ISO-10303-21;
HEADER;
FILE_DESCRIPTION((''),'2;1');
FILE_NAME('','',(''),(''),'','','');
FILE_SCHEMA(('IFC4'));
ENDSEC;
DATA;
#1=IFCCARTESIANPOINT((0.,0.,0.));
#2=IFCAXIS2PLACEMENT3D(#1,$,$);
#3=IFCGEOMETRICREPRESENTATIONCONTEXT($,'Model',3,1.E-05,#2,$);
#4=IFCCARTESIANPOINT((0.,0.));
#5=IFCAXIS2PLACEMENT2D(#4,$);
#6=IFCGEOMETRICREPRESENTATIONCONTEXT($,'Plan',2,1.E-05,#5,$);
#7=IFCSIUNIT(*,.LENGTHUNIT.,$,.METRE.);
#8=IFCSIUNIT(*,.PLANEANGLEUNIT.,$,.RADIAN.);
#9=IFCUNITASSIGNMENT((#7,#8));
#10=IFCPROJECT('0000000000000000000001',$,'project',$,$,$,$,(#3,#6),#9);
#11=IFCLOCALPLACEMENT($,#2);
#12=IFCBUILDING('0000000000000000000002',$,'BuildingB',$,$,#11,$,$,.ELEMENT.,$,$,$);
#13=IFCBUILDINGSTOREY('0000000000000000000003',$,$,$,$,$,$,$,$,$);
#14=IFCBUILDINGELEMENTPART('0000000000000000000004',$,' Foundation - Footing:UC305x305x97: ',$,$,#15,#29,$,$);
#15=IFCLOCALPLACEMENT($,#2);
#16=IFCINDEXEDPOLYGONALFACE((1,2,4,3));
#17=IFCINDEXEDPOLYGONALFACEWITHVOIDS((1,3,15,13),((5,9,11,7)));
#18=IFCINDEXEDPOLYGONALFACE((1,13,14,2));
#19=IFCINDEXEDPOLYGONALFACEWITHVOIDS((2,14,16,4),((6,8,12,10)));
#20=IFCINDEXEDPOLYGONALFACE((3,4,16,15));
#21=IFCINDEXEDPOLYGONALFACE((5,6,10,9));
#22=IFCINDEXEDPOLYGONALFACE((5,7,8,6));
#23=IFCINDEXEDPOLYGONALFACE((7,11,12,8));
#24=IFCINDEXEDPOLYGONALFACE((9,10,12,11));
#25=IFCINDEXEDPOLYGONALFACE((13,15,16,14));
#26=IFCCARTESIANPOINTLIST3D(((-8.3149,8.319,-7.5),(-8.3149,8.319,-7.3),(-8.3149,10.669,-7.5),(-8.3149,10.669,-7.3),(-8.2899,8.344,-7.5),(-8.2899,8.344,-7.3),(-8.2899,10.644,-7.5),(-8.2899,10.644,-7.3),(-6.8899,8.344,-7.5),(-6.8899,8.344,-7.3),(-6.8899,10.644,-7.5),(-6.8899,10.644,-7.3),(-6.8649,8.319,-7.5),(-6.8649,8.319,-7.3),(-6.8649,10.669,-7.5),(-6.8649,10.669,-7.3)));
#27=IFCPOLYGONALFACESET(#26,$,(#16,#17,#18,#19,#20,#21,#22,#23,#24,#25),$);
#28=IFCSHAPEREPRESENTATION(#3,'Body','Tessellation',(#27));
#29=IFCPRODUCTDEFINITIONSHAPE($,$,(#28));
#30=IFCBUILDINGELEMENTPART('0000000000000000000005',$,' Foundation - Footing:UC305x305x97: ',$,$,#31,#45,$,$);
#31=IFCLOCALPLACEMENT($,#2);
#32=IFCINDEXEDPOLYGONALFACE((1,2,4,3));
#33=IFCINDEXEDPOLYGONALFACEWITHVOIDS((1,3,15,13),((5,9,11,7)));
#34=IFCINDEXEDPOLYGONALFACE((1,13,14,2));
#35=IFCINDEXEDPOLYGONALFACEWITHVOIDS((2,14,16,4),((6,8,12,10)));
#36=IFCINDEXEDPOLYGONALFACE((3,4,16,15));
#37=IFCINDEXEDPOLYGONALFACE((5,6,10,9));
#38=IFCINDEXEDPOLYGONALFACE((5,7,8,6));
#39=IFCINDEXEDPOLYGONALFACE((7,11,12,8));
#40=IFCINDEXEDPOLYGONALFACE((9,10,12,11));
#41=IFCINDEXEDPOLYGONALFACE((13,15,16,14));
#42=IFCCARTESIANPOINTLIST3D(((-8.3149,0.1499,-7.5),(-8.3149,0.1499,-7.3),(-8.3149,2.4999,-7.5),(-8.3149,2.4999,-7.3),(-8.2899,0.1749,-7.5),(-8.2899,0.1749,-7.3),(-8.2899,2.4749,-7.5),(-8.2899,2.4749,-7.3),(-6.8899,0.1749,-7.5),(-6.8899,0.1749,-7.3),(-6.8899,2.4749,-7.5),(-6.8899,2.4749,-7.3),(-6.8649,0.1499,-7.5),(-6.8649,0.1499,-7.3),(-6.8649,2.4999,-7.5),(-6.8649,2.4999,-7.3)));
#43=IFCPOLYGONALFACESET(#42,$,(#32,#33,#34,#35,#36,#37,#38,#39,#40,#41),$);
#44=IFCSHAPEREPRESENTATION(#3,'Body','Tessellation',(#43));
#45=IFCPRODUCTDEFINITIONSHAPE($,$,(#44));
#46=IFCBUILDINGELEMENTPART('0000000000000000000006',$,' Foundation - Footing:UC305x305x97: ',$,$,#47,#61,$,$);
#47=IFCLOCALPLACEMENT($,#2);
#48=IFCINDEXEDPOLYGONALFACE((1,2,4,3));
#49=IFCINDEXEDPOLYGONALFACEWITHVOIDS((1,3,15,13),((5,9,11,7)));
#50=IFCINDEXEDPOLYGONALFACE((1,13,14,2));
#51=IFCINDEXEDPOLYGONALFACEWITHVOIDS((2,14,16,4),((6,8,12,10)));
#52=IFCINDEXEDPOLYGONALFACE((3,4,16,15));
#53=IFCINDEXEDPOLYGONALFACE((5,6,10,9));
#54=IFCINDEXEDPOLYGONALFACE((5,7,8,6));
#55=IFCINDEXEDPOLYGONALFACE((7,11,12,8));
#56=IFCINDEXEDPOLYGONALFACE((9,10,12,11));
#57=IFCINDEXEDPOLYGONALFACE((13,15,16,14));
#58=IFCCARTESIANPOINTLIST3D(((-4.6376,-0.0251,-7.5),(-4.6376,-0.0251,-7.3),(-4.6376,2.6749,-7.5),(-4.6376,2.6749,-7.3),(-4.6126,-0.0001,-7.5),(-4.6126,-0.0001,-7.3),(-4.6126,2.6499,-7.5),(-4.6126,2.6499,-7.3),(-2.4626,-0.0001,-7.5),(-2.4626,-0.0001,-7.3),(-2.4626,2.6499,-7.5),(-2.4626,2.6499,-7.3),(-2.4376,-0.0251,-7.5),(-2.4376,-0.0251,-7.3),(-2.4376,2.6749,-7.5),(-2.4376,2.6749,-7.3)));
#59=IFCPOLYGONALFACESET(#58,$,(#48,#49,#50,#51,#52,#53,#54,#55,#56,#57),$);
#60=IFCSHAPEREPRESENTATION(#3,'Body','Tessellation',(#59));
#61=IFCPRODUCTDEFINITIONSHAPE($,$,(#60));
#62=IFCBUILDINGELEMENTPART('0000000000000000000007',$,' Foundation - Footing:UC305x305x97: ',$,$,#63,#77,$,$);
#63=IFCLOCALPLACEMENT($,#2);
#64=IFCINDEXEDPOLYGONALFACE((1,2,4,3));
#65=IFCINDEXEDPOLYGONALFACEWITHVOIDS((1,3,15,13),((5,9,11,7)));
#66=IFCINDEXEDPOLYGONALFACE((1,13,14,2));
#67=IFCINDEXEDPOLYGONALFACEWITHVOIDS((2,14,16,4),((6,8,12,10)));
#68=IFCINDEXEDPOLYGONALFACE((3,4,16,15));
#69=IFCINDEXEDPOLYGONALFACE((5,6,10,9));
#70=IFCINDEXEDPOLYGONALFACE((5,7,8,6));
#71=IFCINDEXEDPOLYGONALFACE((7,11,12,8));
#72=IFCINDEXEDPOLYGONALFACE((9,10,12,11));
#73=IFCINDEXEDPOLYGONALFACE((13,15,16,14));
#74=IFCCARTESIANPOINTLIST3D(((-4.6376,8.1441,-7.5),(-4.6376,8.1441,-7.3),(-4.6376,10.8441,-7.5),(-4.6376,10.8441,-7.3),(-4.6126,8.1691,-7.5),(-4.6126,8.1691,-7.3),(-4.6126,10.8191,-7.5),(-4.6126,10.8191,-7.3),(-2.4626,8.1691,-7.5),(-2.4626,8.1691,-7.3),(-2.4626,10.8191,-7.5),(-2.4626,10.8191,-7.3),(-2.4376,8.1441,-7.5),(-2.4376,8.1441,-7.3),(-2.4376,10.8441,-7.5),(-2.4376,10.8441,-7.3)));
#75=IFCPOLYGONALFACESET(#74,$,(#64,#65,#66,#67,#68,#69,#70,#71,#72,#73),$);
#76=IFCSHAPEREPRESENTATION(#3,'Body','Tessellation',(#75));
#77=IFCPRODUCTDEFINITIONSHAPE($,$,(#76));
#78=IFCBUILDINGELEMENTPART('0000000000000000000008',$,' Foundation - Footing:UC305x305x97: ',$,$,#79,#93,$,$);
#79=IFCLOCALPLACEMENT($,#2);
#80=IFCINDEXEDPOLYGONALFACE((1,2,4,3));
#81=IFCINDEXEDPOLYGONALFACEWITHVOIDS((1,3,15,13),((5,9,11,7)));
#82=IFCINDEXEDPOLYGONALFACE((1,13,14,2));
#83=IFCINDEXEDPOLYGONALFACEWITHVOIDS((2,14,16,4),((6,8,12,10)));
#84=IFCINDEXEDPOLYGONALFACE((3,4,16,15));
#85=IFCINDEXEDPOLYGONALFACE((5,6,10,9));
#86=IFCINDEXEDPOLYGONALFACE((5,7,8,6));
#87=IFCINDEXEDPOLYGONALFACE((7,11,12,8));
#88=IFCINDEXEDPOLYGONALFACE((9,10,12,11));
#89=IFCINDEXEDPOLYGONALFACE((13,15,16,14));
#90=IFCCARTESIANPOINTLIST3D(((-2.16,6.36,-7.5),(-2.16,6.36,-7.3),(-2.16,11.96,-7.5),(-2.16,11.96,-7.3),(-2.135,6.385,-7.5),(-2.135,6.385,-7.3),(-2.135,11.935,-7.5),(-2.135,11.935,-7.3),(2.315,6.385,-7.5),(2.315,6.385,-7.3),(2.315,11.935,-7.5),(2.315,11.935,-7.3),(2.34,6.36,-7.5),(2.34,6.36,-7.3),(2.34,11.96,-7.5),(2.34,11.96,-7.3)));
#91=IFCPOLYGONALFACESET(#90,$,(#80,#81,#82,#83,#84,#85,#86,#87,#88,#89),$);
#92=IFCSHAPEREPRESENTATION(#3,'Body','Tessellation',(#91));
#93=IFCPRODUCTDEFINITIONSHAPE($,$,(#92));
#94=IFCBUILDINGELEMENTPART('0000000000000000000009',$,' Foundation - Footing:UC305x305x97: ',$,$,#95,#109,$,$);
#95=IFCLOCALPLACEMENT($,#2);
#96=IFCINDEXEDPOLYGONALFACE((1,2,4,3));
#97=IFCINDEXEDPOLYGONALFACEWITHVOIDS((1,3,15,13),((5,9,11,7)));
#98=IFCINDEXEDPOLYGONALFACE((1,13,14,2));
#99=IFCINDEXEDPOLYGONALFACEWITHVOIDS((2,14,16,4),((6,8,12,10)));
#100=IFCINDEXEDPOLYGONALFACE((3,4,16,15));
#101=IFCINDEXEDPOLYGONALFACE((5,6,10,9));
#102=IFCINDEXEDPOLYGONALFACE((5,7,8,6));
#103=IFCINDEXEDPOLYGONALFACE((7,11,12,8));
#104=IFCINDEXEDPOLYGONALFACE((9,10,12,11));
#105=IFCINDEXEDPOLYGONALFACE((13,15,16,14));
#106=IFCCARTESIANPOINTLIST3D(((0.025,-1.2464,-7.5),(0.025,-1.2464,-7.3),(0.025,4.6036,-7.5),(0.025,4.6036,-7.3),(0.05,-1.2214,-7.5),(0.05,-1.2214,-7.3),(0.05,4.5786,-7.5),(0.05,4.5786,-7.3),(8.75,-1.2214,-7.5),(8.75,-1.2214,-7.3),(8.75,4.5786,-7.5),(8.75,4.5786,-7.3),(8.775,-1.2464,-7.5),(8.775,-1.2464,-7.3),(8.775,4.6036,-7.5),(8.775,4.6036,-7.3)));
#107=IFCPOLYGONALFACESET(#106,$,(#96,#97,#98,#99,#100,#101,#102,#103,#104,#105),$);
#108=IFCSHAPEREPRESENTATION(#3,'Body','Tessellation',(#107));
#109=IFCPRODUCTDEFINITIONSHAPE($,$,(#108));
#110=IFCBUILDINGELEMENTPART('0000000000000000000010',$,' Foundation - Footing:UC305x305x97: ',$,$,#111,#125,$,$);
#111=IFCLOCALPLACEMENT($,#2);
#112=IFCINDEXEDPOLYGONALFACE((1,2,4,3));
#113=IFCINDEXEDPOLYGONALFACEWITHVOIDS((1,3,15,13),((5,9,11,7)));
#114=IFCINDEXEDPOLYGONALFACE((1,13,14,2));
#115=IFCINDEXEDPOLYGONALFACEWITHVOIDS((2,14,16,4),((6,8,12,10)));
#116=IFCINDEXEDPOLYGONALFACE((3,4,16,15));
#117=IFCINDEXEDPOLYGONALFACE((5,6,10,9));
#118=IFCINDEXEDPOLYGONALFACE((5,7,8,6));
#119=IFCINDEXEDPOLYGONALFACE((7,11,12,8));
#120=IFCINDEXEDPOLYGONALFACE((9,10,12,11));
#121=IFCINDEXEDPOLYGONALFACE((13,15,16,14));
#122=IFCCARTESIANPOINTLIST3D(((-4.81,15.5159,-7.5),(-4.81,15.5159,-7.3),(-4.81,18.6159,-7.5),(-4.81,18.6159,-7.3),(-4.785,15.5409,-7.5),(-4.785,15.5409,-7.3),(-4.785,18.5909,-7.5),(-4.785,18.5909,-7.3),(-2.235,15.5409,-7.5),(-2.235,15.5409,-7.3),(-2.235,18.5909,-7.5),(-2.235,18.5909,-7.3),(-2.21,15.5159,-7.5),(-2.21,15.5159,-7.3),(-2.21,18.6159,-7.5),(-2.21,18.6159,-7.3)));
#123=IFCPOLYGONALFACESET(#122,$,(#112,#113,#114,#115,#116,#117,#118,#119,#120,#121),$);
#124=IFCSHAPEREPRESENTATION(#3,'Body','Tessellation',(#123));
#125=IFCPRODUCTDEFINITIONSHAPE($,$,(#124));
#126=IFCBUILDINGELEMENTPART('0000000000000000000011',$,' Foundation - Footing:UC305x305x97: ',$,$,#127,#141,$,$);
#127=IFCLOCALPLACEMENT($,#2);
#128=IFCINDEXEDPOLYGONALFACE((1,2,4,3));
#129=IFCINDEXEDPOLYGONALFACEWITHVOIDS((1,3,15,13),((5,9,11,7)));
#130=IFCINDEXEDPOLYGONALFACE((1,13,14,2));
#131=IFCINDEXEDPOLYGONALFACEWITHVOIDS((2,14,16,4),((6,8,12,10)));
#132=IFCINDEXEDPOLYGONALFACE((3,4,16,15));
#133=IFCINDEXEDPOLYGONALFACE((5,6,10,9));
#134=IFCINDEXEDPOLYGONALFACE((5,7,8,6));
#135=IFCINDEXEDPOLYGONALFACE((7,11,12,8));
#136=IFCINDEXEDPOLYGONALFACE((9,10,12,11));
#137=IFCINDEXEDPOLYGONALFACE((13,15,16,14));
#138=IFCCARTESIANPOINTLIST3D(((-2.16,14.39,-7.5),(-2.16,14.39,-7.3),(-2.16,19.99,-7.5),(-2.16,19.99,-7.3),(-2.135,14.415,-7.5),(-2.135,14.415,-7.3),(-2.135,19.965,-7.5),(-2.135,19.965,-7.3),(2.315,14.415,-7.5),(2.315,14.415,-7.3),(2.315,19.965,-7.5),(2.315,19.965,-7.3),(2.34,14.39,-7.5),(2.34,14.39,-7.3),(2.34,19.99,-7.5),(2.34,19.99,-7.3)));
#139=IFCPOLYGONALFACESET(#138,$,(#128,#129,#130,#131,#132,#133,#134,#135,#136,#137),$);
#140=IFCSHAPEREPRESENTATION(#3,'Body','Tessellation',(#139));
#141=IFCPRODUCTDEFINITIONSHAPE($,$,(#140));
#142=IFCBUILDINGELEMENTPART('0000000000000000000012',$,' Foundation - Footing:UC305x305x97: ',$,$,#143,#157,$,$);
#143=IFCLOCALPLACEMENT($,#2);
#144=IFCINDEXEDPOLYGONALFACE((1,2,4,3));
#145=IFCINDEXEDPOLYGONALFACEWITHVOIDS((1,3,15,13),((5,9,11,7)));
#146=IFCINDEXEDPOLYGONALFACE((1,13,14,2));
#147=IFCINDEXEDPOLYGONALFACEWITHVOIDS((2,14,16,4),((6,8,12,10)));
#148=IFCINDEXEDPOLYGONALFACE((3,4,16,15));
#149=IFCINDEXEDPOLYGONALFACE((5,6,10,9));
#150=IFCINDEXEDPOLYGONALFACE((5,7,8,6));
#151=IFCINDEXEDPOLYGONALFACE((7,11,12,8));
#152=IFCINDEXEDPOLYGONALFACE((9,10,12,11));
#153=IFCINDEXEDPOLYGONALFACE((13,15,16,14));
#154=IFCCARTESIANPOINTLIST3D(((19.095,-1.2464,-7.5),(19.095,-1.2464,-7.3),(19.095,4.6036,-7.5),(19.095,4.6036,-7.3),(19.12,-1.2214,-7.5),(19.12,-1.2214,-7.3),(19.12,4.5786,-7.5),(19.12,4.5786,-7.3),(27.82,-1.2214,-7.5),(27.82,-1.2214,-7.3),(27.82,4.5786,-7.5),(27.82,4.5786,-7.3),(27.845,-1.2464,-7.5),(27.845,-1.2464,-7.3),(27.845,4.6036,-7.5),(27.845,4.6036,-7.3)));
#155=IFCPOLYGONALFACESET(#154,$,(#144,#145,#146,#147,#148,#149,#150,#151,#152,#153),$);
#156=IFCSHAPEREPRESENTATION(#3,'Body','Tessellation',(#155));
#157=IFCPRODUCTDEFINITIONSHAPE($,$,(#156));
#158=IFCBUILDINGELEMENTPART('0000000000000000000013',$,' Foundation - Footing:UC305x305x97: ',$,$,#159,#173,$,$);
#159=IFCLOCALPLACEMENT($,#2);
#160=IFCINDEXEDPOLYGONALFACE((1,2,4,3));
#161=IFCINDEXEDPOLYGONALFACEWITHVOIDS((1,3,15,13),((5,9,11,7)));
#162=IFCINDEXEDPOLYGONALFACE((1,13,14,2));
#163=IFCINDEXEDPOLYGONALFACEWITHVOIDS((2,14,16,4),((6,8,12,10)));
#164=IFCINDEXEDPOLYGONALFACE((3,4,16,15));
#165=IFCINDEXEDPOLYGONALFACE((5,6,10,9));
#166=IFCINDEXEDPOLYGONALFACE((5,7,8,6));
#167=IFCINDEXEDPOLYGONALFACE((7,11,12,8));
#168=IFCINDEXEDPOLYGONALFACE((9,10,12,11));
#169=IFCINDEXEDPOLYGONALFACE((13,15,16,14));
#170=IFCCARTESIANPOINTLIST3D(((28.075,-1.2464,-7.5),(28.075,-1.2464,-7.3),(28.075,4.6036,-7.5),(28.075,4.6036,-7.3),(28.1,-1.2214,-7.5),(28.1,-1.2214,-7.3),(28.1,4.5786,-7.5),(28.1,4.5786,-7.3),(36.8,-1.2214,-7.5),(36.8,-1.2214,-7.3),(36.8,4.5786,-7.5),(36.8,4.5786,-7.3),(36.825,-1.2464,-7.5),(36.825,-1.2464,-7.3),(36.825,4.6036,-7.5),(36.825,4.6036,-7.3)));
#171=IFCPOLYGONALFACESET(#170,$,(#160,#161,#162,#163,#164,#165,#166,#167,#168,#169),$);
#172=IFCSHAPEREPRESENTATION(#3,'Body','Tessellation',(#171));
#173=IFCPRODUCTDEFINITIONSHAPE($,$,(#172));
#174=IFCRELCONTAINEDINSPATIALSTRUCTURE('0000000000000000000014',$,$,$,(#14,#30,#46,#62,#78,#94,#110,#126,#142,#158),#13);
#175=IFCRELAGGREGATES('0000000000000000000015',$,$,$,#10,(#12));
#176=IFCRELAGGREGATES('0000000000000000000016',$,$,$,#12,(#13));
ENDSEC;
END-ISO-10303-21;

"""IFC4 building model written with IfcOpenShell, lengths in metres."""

from ifc_helpers import new_model, si_unit, origin, origin_2d, place, context, project, spatial, polyline, outline, extrude, element, save


model = new_model("IFC4")

# Units and contexts
model_context = context("Model", 3, precision=1e-05, world=origin())
plan_context = context("Plan", 2, precision=1e-05, world=origin_2d())
ifc_project = project(units=[si_unit("LENGTHUNIT", "METRE"), si_unit("PLANEANGLEUNIT", "RADIAN")], contexts=[model_context, plan_context])

# Building, storey
building_placement = place(None, origin())
building = spatial("IfcBuilding", under=ifc_project, at=building_placement, Name="BuildingB", CompositionType="ELEMENT")
storey = spatial("IfcBuildingStorey", under=building)

# Building element parts, openings
building_element_part_1 = element("IfcBuildingElementPart", 1, inside=storey, Name=" Foundation - Footing:UC305x305x97: ", context=model_context, shape_type="SweptSolid", body=[
    extrude(outline(polyline([(-8.3149, 8.319, -7.5), (-6.8649, 8.319, -7.5), (-6.8649, 10.669, -7.5), (-8.3149, 10.669, -7.5), (-8.3149, 8.319, -7.5)])), None, (0.0, 0.0, 1.0), 0.2),
])
element("IfcOpeningElement", 2, inside=storey, cuts=building_element_part_1, context=model_context, shape_type="SweptSolid", body=[
    extrude(outline(polyline([(-8.2899, 8.344, -7.5), (-6.8899, 8.344, -7.5), (-6.8899, 10.644, -7.5), (-8.2899, 10.644, -7.5), (-8.2899, 8.344, -7.5)])), None, (0.0, 0.0, 1.0), 0.2),
])
building_element_part_2 = element("IfcBuildingElementPart", 3, inside=storey, Name=" Foundation - Footing:UC305x305x97: ", context=model_context, shape_type="SweptSolid", body=[
    extrude(outline(polyline([(-8.3149, 0.1499, -7.5), (-6.8649, 0.1499, -7.5), (-6.8649, 2.4999, -7.5), (-8.3149, 2.4999, -7.5), (-8.3149, 0.1499, -7.5)])), None, (0.0, 0.0, 1.0), 0.2),
])
element("IfcOpeningElement", 4, inside=storey, cuts=building_element_part_2, context=model_context, shape_type="SweptSolid", body=[
    extrude(outline(polyline([(-8.2899, 0.1749, -7.5), (-6.8899, 0.1749, -7.5), (-6.8899, 2.4749, -7.5), (-8.2899, 2.4749, -7.5), (-8.2899, 0.1749, -7.5)])), None, (0.0, 0.0, 1.0), 0.2),
])
building_element_part_3 = element("IfcBuildingElementPart", 5, inside=storey, Name=" Foundation - Footing:UC305x305x97: ", context=model_context, shape_type="SweptSolid", body=[
    extrude(outline(polyline([(-4.6376, -0.0251, -7.5), (-2.4376, -0.0251, -7.5), (-2.4376, 2.6749, -7.5), (-4.6376, 2.6749, -7.5), (-4.6376, -0.0251, -7.5)])), None, (0.0, 0.0, 1.0), 0.2),
])
element("IfcOpeningElement", 6, inside=storey, cuts=building_element_part_3, context=model_context, shape_type="SweptSolid", body=[
    extrude(outline(polyline([(-4.6126, -0.0001, -7.5), (-2.4626, -0.0001, -7.5), (-2.4626, 2.6499, -7.5), (-4.6126, 2.6499, -7.5), (-4.6126, -0.0001, -7.5)])), None, (0.0, 0.0, 1.0), 0.2),
])
building_element_part_4 = element("IfcBuildingElementPart", 7, inside=storey, Name=" Foundation - Footing:UC305x305x97: ", context=model_context, shape_type="SweptSolid", body=[
    extrude(outline(polyline([(-4.6376, 8.1441, -7.5), (-2.4376, 8.1441, -7.5), (-2.4376, 10.8441, -7.5), (-4.6376, 10.8441, -7.5), (-4.6376, 8.1441, -7.5)])), None, (0.0, 0.0, 1.0), 0.2),
])
element("IfcOpeningElement", 8, inside=storey, cuts=building_element_part_4, context=model_context, shape_type="SweptSolid", body=[
    extrude(outline(polyline([(-4.6126, 8.1691, -7.5), (-2.4626, 8.1691, -7.5), (-2.4626, 10.8191, -7.5), (-4.6126, 10.8191, -7.5), (-4.6126, 8.1691, -7.5)])), None, (0.0, 0.0, 1.0), 0.2),
])
building_element_part_5 = element("IfcBuildingElementPart", 9, inside=storey, Name=" Foundation - Footing:UC305x305x97: ", context=model_context, shape_type="SweptSolid", body=[
    extrude(outline(polyline([(-2.16, 6.36, -7.5), (2.34, 6.36, -7.5), (2.34, 11.96, -7.5), (-2.16, 11.96, -7.5), (-2.16, 6.36, -7.5)])), None, (0.0, 0.0, 1.0), 0.2),
])
element("IfcOpeningElement", 10, inside=storey, cuts=building_element_part_5, context=model_context, shape_type="SweptSolid", body=[
    extrude(outline(polyline([(-2.135, 6.385, -7.5), (2.315, 6.385, -7.5), (2.315, 11.935, -7.5), (-2.135, 11.935, -7.5), (-2.135, 6.385, -7.5)])), None, (0.0, 0.0, 1.0), 0.2),
])
building_element_part_6 = element("IfcBuildingElementPart", 11, inside=storey, Name=" Foundation - Footing:UC305x305x97: ", context=model_context, shape_type="SweptSolid", body=[
    extrude(outline(polyline([(0.025, -1.2464, -7.5), (8.775, -1.2464, -7.5), (8.775, 4.6036, -7.5), (0.025, 4.6036, -7.5), (0.025, -1.2464, -7.5)])), None, (0.0, 0.0, 1.0), 0.2),
])
element("IfcOpeningElement", 12, inside=storey, cuts=building_element_part_6, context=model_context, shape_type="SweptSolid", body=[
    extrude(outline(polyline([(0.05, -1.2214, -7.5), (8.75, -1.2214, -7.5), (8.75, 4.5786, -7.5), (0.05, 4.5786, -7.5), (0.05, -1.2214, -7.5)])), None, (0.0, 0.0, 1.0), 0.2),
])
building_element_part_7 = element("IfcBuildingElementPart", 13, inside=storey, Name=" Foundation - Footing:UC305x305x97: ", context=model_context, shape_type="SweptSolid", body=[
    extrude(outline(polyline([(-4.81, 15.5159, -7.5), (-2.21, 15.5159, -7.5), (-2.21, 18.6159, -7.5), (-4.81, 18.6159, -7.5), (-4.81, 15.5159, -7.5)])), None, (0.0, 0.0, 1.0), 0.2),
])
element("IfcOpeningElement", 14, inside=storey, cuts=building_element_part_7, context=model_context, shape_type="SweptSolid", body=[
    extrude(outline(polyline([(-4.785, 15.5409, -7.5), (-2.235, 15.5409, -7.5), (-2.235, 18.5909, -7.5), (-4.785, 18.5909, -7.5), (-4.785, 15.5409, -7.5)])), None, (0.0, 0.0, 1.0), 0.2),
])
building_element_part_8 = element("IfcBuildingElementPart", 15, inside=storey, Name=" Foundation - Footing:UC305x305x97: ", context=model_context, shape_type="SweptSolid", body=[
    extrude(outline(polyline([(-2.16, 14.39, -7.5), (2.34, 14.39, -7.5), (2.34, 19.99, -7.5), (-2.16, 19.99, -7.5), (-2.16, 14.39, -7.5)])), None, (0.0, 0.0, 1.0), 0.2),
])
element("IfcOpeningElement", 16, inside=storey, cuts=building_element_part_8, context=model_context, shape_type="SweptSolid", body=[
    extrude(outline(polyline([(-2.135, 14.415, -7.5), (2.315, 14.415, -7.5), (2.315, 19.965, -7.5), (-2.135, 19.965, -7.5), (-2.135, 14.415, -7.5)])), None, (0.0, 0.0, 1.0), 0.2),
])
building_element_part_9 = element("IfcBuildingElementPart", 17, inside=storey, Name=" Foundation - Footing:UC305x305x97: ", context=model_context, shape_type="SweptSolid", body=[
    extrude(outline(polyline([(19.095, -1.2464, -7.5), (27.845, -1.2464, -7.5), (27.845, 4.6036, -7.5), (19.095, 4.6036, -7.5), (19.095, -1.2464, -7.5)])), None, (0.0, 0.0, 1.0), 0.2),
])
element("IfcOpeningElement", 18, inside=storey, cuts=building_element_part_9, context=model_context, shape_type="SweptSolid", body=[
    extrude(outline(polyline([(19.12, -1.2214, -7.5), (27.82, -1.2214, -7.5), (27.82, 4.5786, -7.5), (19.12, 4.5786, -7.5), (19.12, -1.2214, -7.5)])), None, (0.0, 0.0, 1.0), 0.2),
])
building_element_part_10 = element("IfcBuildingElementPart", 19, inside=storey, Name=" Foundation - Footing:UC305x305x97: ", context=model_context, shape_type="SweptSolid", body=[
    extrude(outline(polyline([(28.075, -1.2464, -7.5), (36.825, -1.2464, -7.5), (36.825, 4.6036, -7.5), (28.075, 4.6036, -7.5), (28.075, -1.2464, -7.5)])), None, (0.0, 0.0, 1.0), 0.2),
])
element("IfcOpeningElement", 20, inside=storey, cuts=building_element_part_10, context=model_context, shape_type="SweptSolid", body=[
    extrude(outline(polyline([(28.1, -1.2214, -7.5), (36.8, -1.2214, -7.5), (36.8, 4.5786, -7.5), (28.1, 4.5786, -7.5), (28.1, -1.2214, -7.5)])), None, (0.0, 0.0, 1.0), 0.2),
])

save(model, "model.ifc")
